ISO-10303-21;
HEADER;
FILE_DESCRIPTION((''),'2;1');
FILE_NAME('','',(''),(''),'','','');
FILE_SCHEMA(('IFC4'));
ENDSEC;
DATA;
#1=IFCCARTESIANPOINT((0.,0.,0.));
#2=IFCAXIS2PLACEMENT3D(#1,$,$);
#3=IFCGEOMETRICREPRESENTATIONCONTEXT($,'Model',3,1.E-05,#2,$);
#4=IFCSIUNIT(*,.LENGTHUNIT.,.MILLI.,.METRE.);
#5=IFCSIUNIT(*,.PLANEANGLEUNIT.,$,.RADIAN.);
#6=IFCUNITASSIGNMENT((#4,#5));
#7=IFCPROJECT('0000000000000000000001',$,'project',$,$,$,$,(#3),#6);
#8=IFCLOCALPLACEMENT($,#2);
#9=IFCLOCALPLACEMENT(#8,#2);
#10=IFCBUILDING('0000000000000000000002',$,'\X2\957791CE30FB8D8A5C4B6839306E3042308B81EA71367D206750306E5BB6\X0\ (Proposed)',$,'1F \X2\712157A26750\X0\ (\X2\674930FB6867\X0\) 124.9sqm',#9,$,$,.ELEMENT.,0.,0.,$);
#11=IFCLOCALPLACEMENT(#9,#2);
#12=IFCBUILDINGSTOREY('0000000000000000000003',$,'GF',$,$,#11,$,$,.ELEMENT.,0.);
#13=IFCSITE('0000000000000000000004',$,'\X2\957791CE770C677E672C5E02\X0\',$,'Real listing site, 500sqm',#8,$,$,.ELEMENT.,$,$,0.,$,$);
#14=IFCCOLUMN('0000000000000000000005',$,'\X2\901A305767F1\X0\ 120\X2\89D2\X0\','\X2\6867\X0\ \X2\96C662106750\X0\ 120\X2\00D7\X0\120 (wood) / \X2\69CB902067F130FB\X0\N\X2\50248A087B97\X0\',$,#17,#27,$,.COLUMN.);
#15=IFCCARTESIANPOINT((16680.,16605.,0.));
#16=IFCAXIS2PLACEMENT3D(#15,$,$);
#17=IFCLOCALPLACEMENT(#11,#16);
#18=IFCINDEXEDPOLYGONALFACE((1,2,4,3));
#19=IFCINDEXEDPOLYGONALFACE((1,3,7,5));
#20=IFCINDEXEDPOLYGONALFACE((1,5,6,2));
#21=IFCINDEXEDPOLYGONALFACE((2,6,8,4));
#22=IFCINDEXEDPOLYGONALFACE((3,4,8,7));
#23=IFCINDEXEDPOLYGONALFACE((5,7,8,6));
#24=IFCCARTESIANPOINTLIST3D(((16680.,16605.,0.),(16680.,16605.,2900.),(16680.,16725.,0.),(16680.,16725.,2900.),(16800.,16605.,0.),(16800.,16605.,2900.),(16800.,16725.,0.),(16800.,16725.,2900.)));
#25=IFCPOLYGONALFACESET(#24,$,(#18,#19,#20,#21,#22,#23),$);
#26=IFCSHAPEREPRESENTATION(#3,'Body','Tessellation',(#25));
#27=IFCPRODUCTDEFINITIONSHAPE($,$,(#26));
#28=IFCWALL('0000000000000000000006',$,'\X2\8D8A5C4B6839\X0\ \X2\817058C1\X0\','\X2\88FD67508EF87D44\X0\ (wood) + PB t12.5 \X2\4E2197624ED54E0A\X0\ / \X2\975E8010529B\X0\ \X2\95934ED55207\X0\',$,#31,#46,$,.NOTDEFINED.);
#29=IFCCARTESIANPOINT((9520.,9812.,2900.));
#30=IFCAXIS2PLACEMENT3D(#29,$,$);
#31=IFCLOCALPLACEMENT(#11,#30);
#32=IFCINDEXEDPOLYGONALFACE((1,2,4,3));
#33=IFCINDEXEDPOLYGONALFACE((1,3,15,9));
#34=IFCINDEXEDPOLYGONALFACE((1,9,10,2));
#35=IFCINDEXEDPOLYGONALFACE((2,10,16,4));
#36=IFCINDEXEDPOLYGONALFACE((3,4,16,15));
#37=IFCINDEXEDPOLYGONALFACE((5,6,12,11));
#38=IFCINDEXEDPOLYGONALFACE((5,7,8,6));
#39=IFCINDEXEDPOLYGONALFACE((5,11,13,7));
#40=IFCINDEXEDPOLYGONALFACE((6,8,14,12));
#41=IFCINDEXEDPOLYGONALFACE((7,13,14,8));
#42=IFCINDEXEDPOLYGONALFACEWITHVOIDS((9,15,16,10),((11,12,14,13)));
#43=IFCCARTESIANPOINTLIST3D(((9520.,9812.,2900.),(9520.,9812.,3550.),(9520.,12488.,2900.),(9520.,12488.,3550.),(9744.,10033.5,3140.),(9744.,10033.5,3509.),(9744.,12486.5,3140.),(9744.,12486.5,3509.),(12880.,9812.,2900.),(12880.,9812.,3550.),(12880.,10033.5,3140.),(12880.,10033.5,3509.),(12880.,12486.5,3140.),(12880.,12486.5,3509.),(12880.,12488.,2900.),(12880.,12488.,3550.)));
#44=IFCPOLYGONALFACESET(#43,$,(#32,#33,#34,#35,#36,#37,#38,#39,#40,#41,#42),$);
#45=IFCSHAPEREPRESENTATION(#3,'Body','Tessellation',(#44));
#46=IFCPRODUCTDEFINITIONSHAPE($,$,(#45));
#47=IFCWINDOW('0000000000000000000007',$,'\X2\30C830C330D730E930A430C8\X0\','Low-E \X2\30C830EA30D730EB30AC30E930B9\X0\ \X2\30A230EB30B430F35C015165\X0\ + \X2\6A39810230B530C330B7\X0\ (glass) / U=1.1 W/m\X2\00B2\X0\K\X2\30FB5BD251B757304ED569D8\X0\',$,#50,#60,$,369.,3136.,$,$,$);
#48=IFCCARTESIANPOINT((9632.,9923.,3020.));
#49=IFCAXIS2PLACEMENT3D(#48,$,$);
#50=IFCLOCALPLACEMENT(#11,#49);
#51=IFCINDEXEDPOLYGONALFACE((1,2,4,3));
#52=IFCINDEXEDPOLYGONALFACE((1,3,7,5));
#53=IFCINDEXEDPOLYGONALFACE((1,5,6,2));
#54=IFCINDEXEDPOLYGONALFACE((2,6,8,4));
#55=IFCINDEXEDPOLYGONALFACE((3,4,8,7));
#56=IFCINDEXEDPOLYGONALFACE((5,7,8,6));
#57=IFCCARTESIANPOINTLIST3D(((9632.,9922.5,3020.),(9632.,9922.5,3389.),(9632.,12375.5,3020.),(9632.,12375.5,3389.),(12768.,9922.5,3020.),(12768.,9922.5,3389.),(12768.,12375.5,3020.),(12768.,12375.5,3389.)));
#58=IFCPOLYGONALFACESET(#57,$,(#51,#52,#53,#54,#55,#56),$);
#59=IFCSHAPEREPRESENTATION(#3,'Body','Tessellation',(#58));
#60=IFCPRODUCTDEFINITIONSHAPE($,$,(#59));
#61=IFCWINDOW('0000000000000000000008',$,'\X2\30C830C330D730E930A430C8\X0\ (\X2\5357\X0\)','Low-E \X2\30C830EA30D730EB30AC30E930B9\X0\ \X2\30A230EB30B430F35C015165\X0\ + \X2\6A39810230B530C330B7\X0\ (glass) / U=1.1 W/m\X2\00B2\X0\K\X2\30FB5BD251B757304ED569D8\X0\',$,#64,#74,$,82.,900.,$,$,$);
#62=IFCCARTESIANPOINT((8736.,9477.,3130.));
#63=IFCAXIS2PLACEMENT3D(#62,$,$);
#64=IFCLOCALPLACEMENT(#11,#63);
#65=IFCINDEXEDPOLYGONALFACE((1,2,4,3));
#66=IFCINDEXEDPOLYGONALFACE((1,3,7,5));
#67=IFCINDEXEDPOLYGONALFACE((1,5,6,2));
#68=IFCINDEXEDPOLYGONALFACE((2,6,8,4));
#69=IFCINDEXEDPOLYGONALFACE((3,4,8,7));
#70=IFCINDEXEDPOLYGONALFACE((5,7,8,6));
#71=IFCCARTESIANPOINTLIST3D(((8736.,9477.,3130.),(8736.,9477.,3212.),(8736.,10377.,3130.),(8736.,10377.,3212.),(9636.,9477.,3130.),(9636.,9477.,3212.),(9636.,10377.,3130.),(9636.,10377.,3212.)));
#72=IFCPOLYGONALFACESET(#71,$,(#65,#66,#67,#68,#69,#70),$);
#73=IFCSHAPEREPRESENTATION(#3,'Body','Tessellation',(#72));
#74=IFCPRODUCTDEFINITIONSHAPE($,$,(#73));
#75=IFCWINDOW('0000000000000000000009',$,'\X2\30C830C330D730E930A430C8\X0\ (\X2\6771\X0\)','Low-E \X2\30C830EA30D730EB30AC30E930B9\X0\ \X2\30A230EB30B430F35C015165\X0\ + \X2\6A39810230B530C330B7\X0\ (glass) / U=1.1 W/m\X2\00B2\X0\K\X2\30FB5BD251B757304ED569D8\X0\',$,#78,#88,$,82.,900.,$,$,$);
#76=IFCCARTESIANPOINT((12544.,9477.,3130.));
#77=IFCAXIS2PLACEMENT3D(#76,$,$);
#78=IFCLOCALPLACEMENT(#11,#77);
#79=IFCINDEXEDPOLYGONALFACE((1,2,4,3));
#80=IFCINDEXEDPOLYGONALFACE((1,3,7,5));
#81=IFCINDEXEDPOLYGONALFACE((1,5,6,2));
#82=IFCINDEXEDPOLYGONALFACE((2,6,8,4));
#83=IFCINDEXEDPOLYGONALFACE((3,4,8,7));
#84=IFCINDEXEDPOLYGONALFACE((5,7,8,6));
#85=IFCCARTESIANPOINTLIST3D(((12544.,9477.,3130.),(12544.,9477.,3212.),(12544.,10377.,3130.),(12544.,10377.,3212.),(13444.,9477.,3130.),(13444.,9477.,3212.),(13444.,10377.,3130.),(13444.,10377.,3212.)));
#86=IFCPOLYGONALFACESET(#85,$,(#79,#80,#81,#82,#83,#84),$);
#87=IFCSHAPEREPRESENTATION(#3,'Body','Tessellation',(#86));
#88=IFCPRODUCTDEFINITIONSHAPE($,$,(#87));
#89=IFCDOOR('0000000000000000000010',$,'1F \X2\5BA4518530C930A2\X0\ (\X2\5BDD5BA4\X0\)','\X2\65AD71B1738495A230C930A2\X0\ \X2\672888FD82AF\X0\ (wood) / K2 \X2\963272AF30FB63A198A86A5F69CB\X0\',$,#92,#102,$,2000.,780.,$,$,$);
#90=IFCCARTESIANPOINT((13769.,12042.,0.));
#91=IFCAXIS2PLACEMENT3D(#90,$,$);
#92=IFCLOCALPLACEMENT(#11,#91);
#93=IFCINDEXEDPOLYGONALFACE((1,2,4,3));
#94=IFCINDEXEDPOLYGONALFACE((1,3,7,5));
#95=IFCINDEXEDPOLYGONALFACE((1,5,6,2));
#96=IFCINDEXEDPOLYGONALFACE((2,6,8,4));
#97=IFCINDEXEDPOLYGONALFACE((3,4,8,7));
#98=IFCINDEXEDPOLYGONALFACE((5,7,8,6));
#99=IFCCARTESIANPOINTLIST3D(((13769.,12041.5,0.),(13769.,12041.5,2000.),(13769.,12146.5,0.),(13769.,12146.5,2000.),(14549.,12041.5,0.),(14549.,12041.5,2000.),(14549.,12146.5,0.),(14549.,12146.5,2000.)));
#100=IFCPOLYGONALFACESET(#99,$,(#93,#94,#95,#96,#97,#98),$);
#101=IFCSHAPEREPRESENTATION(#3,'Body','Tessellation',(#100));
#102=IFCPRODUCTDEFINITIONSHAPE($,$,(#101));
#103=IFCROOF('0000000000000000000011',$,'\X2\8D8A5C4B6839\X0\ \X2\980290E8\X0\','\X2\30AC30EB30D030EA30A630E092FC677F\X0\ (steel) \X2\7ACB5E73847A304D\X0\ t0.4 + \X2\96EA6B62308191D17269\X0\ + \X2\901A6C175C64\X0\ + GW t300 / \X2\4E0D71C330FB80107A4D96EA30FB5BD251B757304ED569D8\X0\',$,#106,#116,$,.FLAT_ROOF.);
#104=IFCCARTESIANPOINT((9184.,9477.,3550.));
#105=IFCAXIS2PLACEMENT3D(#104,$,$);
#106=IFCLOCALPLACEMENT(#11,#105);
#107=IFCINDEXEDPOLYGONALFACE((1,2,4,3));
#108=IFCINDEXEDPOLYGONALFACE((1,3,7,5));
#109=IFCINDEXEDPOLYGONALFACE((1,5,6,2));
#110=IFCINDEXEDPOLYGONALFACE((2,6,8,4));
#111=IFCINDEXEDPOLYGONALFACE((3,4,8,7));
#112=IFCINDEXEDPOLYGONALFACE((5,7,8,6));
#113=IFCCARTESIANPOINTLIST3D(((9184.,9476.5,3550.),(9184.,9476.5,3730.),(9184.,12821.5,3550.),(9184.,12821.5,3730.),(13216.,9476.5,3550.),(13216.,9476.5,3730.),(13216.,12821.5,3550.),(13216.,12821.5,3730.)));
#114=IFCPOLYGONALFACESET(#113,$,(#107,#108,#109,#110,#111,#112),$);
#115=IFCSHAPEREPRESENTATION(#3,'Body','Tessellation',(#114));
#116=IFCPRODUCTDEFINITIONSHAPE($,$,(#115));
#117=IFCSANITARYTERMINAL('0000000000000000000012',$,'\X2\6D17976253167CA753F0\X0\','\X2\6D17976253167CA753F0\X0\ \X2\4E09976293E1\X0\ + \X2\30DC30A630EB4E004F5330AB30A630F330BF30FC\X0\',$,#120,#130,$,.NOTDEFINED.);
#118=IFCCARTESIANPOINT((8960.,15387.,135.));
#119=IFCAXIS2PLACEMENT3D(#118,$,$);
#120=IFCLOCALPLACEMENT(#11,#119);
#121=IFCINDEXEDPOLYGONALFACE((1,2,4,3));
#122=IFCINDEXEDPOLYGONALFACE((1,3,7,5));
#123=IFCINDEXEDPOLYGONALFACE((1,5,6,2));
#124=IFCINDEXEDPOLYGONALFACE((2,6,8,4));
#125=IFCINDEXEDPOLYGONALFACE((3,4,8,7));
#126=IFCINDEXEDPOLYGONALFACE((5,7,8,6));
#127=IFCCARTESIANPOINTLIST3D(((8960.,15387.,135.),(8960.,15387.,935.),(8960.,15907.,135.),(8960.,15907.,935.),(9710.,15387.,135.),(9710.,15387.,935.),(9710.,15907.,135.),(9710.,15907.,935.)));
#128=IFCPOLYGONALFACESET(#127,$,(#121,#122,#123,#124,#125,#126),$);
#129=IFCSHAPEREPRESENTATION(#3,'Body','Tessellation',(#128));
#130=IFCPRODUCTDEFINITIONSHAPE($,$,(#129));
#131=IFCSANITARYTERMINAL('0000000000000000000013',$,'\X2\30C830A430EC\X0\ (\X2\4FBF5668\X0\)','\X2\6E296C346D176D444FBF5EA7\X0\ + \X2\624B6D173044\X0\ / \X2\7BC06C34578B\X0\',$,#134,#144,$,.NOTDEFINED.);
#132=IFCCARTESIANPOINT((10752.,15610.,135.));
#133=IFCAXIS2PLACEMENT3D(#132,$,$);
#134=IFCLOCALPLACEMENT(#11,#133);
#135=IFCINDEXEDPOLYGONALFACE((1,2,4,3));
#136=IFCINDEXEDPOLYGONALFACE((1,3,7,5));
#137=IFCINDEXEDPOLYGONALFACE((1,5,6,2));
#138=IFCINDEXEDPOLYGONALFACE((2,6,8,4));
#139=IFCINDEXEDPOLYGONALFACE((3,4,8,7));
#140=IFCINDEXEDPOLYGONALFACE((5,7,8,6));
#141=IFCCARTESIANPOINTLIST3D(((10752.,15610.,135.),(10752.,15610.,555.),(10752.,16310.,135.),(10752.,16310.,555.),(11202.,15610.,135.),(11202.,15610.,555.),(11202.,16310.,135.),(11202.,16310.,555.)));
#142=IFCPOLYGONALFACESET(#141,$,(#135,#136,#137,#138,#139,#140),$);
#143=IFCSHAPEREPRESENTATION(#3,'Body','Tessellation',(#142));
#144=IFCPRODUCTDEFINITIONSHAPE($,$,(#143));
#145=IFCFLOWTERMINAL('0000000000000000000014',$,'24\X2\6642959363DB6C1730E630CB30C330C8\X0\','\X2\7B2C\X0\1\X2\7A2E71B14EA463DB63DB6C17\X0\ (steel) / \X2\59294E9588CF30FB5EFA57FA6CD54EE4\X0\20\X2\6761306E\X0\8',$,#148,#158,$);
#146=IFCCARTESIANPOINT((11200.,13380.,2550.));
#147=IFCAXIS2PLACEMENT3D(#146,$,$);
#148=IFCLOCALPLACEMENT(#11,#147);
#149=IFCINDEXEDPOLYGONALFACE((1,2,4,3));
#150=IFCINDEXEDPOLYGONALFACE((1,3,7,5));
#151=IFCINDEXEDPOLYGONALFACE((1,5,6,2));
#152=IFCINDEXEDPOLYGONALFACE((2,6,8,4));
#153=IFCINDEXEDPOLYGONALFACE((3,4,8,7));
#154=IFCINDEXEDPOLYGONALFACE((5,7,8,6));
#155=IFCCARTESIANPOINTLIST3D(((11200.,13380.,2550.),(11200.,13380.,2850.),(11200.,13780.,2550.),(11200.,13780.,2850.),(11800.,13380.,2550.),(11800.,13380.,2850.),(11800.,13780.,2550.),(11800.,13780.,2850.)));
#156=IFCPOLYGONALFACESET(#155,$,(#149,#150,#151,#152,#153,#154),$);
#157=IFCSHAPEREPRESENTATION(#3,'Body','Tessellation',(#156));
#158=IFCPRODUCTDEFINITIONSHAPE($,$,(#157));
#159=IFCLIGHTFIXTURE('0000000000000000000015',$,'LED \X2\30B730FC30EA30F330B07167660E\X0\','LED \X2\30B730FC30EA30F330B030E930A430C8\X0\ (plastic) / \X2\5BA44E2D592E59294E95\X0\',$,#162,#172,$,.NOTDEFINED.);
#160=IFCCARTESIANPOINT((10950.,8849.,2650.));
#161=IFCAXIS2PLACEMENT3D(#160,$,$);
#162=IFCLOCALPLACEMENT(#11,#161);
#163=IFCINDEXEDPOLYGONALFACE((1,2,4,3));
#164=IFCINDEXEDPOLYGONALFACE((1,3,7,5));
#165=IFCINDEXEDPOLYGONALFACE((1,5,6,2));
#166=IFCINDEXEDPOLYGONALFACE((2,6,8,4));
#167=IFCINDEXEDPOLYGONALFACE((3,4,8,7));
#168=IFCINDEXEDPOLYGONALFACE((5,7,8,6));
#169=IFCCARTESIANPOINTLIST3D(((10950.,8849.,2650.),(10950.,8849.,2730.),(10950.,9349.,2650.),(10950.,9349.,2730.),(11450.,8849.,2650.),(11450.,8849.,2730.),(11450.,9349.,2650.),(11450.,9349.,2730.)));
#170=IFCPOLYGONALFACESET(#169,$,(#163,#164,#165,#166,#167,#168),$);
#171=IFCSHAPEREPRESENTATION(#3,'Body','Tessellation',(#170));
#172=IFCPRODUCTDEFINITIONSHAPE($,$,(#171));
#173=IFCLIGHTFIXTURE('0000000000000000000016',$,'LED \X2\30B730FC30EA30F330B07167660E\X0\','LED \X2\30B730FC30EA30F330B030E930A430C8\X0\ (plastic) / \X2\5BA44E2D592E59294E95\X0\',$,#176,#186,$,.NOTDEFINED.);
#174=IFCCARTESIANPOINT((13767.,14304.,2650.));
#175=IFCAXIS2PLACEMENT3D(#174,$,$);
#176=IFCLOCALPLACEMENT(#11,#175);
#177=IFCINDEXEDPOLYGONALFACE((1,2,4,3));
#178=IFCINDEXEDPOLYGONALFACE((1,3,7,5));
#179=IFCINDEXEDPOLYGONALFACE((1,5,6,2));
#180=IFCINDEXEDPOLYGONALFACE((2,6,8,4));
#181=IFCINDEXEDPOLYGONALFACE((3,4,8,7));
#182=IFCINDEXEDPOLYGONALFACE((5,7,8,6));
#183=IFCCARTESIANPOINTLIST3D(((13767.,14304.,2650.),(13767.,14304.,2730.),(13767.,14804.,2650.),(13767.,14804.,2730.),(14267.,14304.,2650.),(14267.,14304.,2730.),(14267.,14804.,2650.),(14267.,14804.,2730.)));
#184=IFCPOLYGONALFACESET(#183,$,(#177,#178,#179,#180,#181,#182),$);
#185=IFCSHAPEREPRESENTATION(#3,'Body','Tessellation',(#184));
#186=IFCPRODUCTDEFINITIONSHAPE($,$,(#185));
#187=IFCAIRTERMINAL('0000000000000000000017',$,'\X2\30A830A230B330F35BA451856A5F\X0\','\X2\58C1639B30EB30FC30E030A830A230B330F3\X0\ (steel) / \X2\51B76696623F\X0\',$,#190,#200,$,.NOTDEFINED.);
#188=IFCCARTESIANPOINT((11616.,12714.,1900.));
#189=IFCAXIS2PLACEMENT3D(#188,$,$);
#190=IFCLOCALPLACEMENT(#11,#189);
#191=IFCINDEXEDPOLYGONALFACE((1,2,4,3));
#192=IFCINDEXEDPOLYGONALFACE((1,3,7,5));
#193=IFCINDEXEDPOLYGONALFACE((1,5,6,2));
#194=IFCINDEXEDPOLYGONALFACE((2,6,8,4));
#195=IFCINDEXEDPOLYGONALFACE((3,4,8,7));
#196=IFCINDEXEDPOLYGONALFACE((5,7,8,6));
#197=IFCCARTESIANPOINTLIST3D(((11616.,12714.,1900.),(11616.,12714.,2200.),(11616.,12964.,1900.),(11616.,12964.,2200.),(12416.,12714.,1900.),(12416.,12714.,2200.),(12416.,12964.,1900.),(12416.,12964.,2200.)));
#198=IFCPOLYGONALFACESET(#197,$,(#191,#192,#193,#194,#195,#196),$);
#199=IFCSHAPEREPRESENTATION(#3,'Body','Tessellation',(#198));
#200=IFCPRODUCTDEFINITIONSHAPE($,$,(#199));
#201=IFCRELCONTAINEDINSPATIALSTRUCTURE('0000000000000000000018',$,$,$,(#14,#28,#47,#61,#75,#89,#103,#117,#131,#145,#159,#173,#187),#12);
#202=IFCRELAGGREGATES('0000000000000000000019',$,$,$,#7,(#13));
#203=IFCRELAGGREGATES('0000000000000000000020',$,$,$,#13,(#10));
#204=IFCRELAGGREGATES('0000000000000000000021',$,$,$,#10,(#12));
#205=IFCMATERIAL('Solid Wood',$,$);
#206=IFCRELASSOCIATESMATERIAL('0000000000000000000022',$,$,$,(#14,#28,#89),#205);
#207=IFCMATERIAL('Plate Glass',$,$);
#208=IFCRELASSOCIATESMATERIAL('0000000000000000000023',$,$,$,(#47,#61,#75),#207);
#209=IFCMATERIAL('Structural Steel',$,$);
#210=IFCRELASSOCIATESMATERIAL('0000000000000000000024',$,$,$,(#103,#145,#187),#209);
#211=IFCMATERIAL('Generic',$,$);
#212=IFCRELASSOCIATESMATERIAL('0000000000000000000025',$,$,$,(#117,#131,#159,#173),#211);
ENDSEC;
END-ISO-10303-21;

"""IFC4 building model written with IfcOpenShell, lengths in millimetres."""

from ifc_helpers import new_model, si_unit, frame, frame_2d, origin, place, context, project, spatial, rectangle, extrude, material, element, fill, save


model = new_model("IFC4")

# Units and contexts
model_context = context("Model", 3, precision=1e-05, world=origin())
ifc_project = project(units=[si_unit("LENGTHUNIT", "METRE", prefix="MILLI"), si_unit("PLANEANGLEUNIT", "RADIAN")], contexts=[model_context])

# Site, building, storey
site_placement = place(None, origin())
site = spatial("IfcSite", under=ifc_project, at=site_placement, Name="長野県松本市", ObjectType="Real listing site, 500sqm", CompositionType="ELEMENT", RefElevation=0.0)
building_placement = place(site_placement, origin())
building = spatial("IfcBuilding", under=site, at=building_placement, Name="長野・越屋根のある自然素材の家 (Proposed)", ObjectType="1F 無垢材 (杉・桧) 124.9sqm", CompositionType="ELEMENT", ElevationOfRefHeight=0.0, ElevationOfTerrain=0.0)
storey_placement = place(building_placement, origin())
storey = spatial("IfcBuildingStorey", under=building, at=storey_placement, Name="GF", CompositionType="ELEMENT", Elevation=0.0)

# Column
ifc_material_1 = material(Name="Solid Wood")
column_1_placement = place(storey_placement, frame((16680.0, 16605.0, 0.0)))
element("IfcColumn", 1, at=column_1_placement, inside=storey, material=ifc_material_1, Name="通し柱 120角", Description="桧 集成材 120×120 (wood) / 構造柱・N値計算", PredefinedType="COLUMN", context=model_context, shape_type="SweptSolid", body=[
    extrude(rectangle(XDim=120.0, YDim=120.0, at=frame_2d((60.0, 60.0))), frame((16680.0, 16605.0, 0.0)), (0.0, 0.0, 1.0), 2900.0),
])

# Wall, openings, windows
wall_1_placement = place(storey_placement, frame((9520.0, 9812.0, 2900.0)))
wall_1 = element("IfcWall", 2, at=wall_1_placement, inside=storey, material=ifc_material_1, Name="越屋根 腰壁", Description="製材軸組 (wood) + PB t12.5 両面仕上 / 非耐力 間仕切", PredefinedType="NOTDEFINED", context=model_context, shape_type="SweptSolid", body=[
    extrude(rectangle(XDim=3360.0, YDim=2676.0, at=frame_2d((1680.0, 1338.0))), frame((9520.0, 9812.0, 2900.0)), (0.0, 0.0, 1.0), 650.0),
])
opening_1_placement = place(storey_placement, frame((9632.0, 9923.0, 3020.0)))
opening_1 = element("IfcOpeningElement", 3, at=opening_1_placement, cuts=wall_1, PredefinedType="NOTDEFINED", context=model_context, shape_type="SweptSolid", body=[
    extrude(rectangle(XDim=3136.0, YDim=2453.0, at=frame_2d((1568.0, 1226.0))), frame((9632.0, 9923.0, 3020.0)), (0.0, 0.0, 1.0), 369.0),
])
opening_2_placement = place(storey_placement, frame((8736.0, 9477.0, 3130.0)))
opening_2 = element("IfcOpeningElement", 4, at=opening_2_placement, cuts=wall_1, PredefinedType="NOTDEFINED", context=model_context, shape_type="SweptSolid", body=[
    extrude(rectangle(XDim=900.0, YDim=900.0, at=frame_2d((450.0, 450.0))), frame((8736.0, 9477.0, 3130.0)), (0.0, 0.0, 1.0), 82.0),
])
opening_3_placement = place(storey_placement, frame((12544.0, 9477.0, 3130.0)))
opening_3 = element("IfcOpeningElement", 5, at=opening_3_placement, cuts=wall_1, PredefinedType="NOTDEFINED", context=model_context, shape_type="SweptSolid", body=[
    extrude(rectangle(XDim=900.0, YDim=900.0, at=frame_2d((450.0, 450.0))), frame((12544.0, 9477.0, 3130.0)), (0.0, 0.0, 1.0), 82.0),
])
ifc_material_2 = material(Name="Plate Glass")
window_1_placement = place(storey_placement, frame((9632.0, 9923.0, 3020.0)))
window_1 = element("IfcWindow", 6, at=window_1_placement, inside=storey, material=ifc_material_2, Name="トップライト", Description="Low-E トリプルガラス アルゴン封入 + 樹脂サッシ (glass) / U=1.1 W/m²K・寒冷地仕様", OverallHeight=369.0, OverallWidth=3136.0, context=model_context, shape_type="SweptSolid", body=[
    extrude(rectangle(XDim=3136.0, YDim=2453.0, at=frame_2d((1568.0, 1226.0))), frame((9632.0, 9923.0, 3020.0)), (0.0, 0.0, 1.0), 369.0),
])
fill(opening_1, window_1)
window_2_placement = place(storey_placement, frame((8736.0, 9477.0, 3130.0)))
window_2 = element("IfcWindow", 7, at=window_2_placement, inside=storey, material=ifc_material_2, Name="トップライト (南)", Description="Low-E トリプルガラス アルゴン封入 + 樹脂サッシ (glass) / U=1.1 W/m²K・寒冷地仕様", OverallHeight=82.0, OverallWidth=900.0, context=model_context, shape_type="SweptSolid", body=[
    extrude(rectangle(XDim=900.0, YDim=900.0, at=frame_2d((450.0, 450.0))), frame((8736.0, 9477.0, 3130.0)), (0.0, 0.0, 1.0), 82.0),
])
fill(opening_2, window_2)
window_3_placement = place(storey_placement, frame((12544.0, 9477.0, 3130.0)))
window_3 = element("IfcWindow", 8, at=window_3_placement, inside=storey, material=ifc_material_2, Name="トップライト (東)", Description="Low-E トリプルガラス アルゴン封入 + 樹脂サッシ (glass) / U=1.1 W/m²K・寒冷地仕様", OverallHeight=82.0, OverallWidth=900.0, context=model_context, shape_type="SweptSolid", body=[
    extrude(rectangle(XDim=900.0, YDim=900.0, at=frame_2d((450.0, 450.0))), frame((12544.0, 9477.0, 3130.0)), (0.0, 0.0, 1.0), 82.0),
])
fill(opening_3, window_3)

# Door
door_placement = place(storey_placement, frame((13769.0, 12042.0, 0.0)))
element("IfcDoor", 9, at=door_placement, inside=storey, material=ifc_material_1, Name="1F 室内ドア (寝室)", Description="断熱玄関ドア 木製芯 (wood) / K2 防犯・採風機構", OverallHeight=2000.0, OverallWidth=780.0, context=model_context, shape_type="SweptSolid", body=[
    extrude(rectangle(XDim=780.0, YDim=105.0, at=frame_2d((390.0, 52.0))), frame((13769.0, 12042.0, 0.0)), (0.0, 0.0, 1.0), 2000.0),
])

# Roof
ifc_material_3 = material(Name="Structural Steel")
roof_placement = place(storey_placement, frame((9184.0, 9477.0, 3550.0)))
element("IfcRoof", 10, at=roof_placement, inside=storey, material=ifc_material_3, Name="越屋根 頂部", Description="ガルバリウム鋼板 (steel) 立平葺き t0.4 + 雪止め金物 + 通気層 + GW t300 / 不燃・耐積雪・寒冷地仕様", PredefinedType="FLAT_ROOF", context=model_context, shape_type="SweptSolid", body=[
    extrude(rectangle(XDim=4032.0, YDim=3345.0, at=frame_2d((2016.0, 1672.0))), frame((9184.0, 9477.0, 3550.0)), (0.0, 0.0, 1.0), 180.0),
])

# Sanitary terminals
ifc_material_4 = material(Name="Generic")
sanitary_terminal_1_placement = place(storey_placement, frame((8960.0, 15387.0, 135.0)))
element("IfcSanitaryTerminal", 11, at=sanitary_terminal_1_placement, inside=storey, material=ifc_material_4, Name="洗面化粧台", Description="洗面化粧台 三面鏡 + ボウル一体カウンター", PredefinedType="NOTDEFINED", context=model_context, shape_type="SweptSolid", body=[
    extrude(rectangle(XDim=750.0, YDim=520.0, at=frame_2d((375.0, 260.0))), frame((8960.0, 15387.0, 135.0)), (0.0, 0.0, 1.0), 800.0),
])
sanitary_terminal_2_placement = place(storey_placement, frame((10752.0, 15610.0, 135.0)))
element("IfcSanitaryTerminal", 12, at=sanitary_terminal_2_placement, inside=storey, material=ifc_material_4, Name="トイレ (便器)", Description="温水洗浄便座 + 手洗い / 節水型", PredefinedType="NOTDEFINED", context=model_context, shape_type="SweptSolid", body=[
    extrude(rectangle(XDim=450.0, YDim=700.0, at=frame_2d((225.0, 350.0))), frame((10752.0, 15610.0, 135.0)), (0.0, 0.0, 1.0), 420.0),
])

# Flow terminal
flow_terminal_placement = place(storey_placement, frame((11200.0, 13380.0, 2550.0)))
element("IfcFlowTerminal", 13, at=flow_terminal_placement, inside=storey, material=ifc_material_3, Name="24時間換気ユニット", Description="第1種熱交換換気 (steel) / 天井裏・建基法令20条の8", context=model_context, shape_type="SweptSolid", body=[
    extrude(rectangle(XDim=600.0, YDim=400.0, at=frame_2d((300.0, 200.0))), frame((11200.0, 13380.0, 2550.0)), (0.0, 0.0, 1.0), 300.0),
])

# Light fixtures
light_fixture_1_placement = place(storey_placement, frame((10950.0, 8849.0, 2650.0)))
element("IfcLightFixture", 14, at=light_fixture_1_placement, inside=storey, material=ifc_material_4, Name="LED シーリング照明", Description="LED シーリングライト (plastic) / 室中央天井", PredefinedType="NOTDEFINED", context=model_context, shape_type="SweptSolid", body=[
    extrude(rectangle(XDim=500.0, YDim=500.0, at=frame_2d((250.0, 250.0))), frame((10950.0, 8849.0, 2650.0)), (0.0, 0.0, 1.0), 80.0),
])
light_fixture_2_placement = place(storey_placement, frame((13767.0, 14304.0, 2650.0)))
element("IfcLightFixture", 15, at=light_fixture_2_placement, inside=storey, material=ifc_material_4, Name="LED シーリング照明", Description="LED シーリングライト (plastic) / 室中央天井", PredefinedType="NOTDEFINED", context=model_context, shape_type="SweptSolid", body=[
    extrude(rectangle(XDim=500.0, YDim=500.0, at=frame_2d((250.0, 250.0))), frame((13767.0, 14304.0, 2650.0)), (0.0, 0.0, 1.0), 80.0),
])

# Air terminal
air_terminal_placement = place(storey_placement, frame((11616.0, 12714.0, 1900.0)))
element("IfcAirTerminal", 16, at=air_terminal_placement, inside=storey, material=ifc_material_3, Name="エアコン室内機", Description="壁掛ルームエアコン (steel) / 冷暖房", PredefinedType="NOTDEFINED", context=model_context, shape_type="SweptSolid", body=[
    extrude(rectangle(XDim=800.0, YDim=250.0, at=frame_2d((400.0, 125.0))), frame((11616.0, 12714.0, 1900.0)), (0.0, 0.0, 1.0), 300.0),
])

save(model, "model.ifc")
